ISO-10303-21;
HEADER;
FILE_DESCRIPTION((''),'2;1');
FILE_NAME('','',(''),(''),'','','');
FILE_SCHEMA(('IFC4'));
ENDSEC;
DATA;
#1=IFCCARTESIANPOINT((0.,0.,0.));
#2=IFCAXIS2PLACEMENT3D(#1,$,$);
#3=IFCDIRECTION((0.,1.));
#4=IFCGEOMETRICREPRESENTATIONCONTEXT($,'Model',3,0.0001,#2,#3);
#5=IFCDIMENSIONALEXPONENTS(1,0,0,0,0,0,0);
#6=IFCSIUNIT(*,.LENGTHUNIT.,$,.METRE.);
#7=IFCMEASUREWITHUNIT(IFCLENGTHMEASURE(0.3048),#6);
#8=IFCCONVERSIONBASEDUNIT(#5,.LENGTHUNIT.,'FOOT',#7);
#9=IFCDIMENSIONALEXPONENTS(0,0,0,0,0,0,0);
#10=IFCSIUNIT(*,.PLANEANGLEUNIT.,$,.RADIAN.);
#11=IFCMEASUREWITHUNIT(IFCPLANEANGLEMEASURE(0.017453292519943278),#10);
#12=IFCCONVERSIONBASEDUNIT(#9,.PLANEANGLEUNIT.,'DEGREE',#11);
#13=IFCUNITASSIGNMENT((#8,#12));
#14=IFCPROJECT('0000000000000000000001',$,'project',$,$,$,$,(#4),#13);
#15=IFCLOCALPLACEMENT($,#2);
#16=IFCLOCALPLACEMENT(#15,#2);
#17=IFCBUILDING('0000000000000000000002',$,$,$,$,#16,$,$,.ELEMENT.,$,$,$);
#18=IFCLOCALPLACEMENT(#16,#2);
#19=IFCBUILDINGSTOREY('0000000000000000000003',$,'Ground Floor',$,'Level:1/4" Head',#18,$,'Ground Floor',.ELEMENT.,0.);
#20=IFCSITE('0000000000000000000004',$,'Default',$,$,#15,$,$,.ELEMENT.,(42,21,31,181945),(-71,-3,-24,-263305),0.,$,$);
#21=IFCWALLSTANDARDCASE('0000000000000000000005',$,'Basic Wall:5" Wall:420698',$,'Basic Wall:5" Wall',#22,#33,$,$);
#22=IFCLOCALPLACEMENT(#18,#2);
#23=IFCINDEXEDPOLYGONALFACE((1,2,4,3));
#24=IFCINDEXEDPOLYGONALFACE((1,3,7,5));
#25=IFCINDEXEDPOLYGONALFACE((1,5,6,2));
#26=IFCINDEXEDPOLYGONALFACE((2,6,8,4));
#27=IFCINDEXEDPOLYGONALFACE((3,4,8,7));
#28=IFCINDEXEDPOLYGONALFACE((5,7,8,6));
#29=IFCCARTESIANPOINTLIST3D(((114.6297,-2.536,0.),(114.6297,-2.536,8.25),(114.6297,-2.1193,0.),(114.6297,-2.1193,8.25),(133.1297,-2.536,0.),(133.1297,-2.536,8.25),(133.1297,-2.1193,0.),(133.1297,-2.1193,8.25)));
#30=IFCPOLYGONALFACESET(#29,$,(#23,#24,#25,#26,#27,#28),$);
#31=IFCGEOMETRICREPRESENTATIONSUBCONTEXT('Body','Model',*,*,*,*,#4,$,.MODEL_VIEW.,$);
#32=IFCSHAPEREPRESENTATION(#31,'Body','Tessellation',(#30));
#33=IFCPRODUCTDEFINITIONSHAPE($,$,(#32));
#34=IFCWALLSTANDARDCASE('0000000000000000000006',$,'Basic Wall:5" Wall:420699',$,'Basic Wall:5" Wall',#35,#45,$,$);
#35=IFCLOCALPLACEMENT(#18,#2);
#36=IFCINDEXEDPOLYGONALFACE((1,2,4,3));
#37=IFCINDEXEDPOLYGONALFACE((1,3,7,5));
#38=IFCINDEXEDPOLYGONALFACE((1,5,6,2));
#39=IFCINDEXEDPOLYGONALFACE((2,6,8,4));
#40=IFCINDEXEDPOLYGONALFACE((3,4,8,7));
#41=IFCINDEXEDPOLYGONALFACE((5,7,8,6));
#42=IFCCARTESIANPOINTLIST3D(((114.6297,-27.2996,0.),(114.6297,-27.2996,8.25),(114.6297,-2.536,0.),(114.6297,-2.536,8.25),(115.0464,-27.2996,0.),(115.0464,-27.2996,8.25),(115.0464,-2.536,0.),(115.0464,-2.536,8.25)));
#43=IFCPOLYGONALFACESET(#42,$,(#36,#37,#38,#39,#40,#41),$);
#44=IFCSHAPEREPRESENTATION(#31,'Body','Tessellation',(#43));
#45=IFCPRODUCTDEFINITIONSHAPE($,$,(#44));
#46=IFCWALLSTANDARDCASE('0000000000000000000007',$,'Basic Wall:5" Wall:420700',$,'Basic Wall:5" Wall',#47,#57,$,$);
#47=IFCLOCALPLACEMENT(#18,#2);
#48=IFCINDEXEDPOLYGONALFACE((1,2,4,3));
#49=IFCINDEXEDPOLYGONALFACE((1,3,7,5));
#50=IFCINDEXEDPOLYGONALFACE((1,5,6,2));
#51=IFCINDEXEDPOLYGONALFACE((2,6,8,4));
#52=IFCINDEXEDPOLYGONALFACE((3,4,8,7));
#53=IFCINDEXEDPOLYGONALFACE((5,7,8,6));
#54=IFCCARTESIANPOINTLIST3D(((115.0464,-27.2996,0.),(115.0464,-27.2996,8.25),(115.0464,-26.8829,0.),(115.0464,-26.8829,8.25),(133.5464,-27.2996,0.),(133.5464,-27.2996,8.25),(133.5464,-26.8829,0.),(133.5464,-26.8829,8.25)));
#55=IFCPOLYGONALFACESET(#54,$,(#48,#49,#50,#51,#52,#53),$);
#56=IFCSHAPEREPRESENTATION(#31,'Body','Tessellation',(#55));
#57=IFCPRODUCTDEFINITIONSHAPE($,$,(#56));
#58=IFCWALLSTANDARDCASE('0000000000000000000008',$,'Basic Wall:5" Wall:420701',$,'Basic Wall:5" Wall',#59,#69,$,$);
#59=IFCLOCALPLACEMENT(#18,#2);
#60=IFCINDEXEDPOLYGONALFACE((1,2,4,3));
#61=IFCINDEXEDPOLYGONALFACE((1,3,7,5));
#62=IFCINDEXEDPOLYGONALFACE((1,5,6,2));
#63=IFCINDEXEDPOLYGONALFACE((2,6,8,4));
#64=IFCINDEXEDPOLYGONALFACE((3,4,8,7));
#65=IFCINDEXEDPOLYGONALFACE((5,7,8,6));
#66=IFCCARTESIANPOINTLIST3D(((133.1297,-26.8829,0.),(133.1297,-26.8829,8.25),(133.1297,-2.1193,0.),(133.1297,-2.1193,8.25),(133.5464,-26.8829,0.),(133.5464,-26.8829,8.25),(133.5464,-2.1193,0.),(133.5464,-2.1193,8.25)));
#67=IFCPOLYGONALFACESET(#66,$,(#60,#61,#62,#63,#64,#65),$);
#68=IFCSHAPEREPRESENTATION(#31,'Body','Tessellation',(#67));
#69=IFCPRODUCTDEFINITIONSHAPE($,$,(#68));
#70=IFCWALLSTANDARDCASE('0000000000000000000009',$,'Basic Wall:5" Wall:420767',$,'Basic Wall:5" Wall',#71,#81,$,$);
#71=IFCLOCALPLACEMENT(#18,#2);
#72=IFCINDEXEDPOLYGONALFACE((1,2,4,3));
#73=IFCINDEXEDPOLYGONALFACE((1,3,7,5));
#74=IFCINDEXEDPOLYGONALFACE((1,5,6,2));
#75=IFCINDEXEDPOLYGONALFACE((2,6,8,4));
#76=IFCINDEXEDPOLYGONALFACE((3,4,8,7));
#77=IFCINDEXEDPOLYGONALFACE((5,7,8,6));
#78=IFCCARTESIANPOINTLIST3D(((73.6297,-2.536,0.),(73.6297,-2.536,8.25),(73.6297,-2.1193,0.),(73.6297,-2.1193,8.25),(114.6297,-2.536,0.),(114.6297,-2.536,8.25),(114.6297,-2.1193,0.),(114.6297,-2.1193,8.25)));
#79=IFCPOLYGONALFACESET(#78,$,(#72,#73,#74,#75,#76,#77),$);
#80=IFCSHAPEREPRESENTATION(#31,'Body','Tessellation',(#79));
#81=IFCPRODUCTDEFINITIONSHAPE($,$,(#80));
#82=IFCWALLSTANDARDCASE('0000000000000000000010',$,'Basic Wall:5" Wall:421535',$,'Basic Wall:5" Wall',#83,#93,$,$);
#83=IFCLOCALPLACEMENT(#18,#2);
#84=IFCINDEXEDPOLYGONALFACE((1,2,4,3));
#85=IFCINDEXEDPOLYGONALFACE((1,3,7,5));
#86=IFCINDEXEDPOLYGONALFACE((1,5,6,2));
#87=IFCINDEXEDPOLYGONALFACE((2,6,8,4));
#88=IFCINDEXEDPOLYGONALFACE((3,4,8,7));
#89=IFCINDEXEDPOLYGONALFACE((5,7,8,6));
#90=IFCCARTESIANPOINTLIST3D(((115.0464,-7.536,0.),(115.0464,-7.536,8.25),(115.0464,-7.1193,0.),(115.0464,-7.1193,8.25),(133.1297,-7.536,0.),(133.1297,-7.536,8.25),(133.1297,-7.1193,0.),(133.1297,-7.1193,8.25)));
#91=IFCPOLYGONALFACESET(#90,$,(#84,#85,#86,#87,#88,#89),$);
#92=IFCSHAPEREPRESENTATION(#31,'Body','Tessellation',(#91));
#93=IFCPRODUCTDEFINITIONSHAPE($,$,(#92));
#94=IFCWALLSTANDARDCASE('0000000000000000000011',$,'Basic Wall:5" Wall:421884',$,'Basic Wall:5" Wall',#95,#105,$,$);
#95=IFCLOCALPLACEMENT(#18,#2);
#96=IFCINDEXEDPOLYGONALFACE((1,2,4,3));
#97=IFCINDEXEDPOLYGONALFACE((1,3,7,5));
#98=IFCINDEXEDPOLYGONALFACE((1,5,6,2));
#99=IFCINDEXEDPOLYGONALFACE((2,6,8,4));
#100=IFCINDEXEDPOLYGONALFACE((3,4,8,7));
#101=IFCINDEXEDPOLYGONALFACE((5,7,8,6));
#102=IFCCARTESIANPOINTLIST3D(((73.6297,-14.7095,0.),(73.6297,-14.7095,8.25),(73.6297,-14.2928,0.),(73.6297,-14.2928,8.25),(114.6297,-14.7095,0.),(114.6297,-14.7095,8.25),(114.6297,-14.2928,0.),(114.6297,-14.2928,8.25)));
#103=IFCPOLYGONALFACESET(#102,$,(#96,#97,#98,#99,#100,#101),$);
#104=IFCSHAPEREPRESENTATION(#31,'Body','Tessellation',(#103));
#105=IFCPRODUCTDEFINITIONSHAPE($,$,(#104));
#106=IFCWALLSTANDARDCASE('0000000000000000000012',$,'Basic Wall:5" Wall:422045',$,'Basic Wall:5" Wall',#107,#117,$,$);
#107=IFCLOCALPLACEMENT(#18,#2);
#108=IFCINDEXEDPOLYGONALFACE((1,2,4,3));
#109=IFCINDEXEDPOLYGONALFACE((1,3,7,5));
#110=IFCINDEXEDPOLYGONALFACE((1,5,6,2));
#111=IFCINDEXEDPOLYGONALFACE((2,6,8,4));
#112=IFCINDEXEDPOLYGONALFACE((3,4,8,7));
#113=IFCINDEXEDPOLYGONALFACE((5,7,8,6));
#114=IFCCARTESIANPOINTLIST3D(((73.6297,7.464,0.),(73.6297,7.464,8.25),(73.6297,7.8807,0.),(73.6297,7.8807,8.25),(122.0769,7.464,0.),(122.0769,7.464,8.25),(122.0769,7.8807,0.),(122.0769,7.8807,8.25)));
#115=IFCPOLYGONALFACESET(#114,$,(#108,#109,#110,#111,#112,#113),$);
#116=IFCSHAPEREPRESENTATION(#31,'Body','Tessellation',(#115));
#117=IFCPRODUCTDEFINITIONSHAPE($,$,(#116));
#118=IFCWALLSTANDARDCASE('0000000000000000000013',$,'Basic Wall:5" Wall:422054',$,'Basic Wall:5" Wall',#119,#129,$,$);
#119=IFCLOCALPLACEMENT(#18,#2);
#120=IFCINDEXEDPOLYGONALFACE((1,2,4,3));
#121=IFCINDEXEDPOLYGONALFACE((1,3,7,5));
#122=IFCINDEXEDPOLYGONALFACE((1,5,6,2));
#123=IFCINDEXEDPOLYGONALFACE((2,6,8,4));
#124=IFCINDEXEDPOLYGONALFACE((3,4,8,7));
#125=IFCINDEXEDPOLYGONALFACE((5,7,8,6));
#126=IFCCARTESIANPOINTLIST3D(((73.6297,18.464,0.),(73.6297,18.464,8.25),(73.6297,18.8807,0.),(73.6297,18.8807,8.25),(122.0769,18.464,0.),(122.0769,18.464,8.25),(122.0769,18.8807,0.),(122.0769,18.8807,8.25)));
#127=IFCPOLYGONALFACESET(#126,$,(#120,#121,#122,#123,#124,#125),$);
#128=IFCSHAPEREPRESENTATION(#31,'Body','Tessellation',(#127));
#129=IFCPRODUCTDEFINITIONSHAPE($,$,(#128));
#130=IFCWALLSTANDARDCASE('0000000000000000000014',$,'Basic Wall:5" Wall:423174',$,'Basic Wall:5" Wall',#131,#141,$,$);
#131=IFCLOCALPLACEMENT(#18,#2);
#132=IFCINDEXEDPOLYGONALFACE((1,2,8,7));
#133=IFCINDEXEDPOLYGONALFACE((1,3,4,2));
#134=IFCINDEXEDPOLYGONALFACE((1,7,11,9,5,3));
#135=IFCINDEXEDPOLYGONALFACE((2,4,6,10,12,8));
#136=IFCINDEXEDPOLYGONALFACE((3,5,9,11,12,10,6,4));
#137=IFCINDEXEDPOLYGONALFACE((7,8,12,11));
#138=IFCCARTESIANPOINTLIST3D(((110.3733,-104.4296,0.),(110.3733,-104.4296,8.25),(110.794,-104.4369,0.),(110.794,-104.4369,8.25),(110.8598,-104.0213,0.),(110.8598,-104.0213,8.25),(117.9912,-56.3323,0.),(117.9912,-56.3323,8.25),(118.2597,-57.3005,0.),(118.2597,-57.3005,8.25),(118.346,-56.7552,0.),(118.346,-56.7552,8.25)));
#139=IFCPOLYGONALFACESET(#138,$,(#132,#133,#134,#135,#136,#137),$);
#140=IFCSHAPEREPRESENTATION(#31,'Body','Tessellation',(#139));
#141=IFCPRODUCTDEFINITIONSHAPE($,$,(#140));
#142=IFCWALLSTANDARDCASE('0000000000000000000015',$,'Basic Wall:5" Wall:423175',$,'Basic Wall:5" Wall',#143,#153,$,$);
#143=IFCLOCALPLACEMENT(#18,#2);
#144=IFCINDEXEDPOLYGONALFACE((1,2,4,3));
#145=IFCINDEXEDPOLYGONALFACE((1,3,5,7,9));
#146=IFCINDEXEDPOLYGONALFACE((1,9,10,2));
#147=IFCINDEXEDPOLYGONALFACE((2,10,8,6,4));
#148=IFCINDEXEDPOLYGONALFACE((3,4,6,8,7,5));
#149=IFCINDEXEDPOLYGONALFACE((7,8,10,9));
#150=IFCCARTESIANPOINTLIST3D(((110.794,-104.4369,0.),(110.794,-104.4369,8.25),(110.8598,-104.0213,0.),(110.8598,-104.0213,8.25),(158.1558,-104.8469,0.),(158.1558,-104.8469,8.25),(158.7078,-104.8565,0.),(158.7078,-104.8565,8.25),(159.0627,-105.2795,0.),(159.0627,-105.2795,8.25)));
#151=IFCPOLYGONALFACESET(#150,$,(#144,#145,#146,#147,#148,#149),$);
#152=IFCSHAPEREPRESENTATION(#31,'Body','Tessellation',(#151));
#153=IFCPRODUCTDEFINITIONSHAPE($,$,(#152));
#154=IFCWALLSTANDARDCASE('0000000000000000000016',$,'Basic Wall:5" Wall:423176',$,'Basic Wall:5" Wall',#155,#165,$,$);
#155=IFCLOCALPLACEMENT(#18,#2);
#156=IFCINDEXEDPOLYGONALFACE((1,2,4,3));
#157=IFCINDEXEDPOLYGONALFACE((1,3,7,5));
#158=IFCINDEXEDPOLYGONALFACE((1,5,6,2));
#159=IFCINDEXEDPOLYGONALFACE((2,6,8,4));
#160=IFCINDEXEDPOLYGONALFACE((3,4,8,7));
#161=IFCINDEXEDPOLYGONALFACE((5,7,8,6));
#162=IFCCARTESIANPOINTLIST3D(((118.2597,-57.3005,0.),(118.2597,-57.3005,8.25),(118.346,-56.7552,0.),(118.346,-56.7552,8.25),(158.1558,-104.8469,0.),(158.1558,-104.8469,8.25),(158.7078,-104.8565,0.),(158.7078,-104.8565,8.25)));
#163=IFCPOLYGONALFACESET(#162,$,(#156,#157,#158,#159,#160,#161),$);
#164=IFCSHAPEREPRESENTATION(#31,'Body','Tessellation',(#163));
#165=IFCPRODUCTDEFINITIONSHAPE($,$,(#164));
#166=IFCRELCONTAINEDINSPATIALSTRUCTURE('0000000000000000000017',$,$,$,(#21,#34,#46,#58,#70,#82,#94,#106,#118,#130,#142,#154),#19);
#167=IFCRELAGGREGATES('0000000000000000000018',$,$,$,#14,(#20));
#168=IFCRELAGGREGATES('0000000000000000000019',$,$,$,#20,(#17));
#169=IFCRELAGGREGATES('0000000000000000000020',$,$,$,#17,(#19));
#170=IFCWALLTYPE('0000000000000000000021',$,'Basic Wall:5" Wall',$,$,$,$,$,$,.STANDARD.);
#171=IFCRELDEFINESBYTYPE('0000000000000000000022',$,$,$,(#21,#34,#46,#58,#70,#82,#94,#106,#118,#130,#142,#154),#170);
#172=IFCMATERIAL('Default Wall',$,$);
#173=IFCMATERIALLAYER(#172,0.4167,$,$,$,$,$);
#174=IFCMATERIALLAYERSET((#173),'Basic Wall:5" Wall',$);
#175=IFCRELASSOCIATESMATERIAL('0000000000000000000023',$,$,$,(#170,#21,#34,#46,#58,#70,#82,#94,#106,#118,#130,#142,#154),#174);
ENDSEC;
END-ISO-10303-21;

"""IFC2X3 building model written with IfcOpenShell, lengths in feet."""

from ifc_helpers import new_model, entity, si_unit, converted_unit, direction, frame, frame_2d, origin, place, context, subcontext, project, spatial, polyline, rectangle, outline, extrude, material, layer, layer_set, layer_usage, type_object, element, save


model = new_model("IFC2X3")

# Units and contexts
model_context = context("Model", 3, precision=0.0001, world=origin(), true_north=direction((0.0, 1.0)))
body_context = subcontext(model_context, "Body", "Model", "MODEL_VIEW")
ifc_project = project(units=[converted_unit("LENGTHUNIT", "FOOT", entity("IfcLengthMeasure", 0.3048), si_unit("LENGTHUNIT", "METRE"), dimensions=[1, 0, 0, 0, 0, 0, 0]), converted_unit("PLANEANGLEUNIT", "DEGREE", entity("IfcPlaneAngleMeasure", 0.017453292519943278), si_unit("PLANEANGLEUNIT", "RADIAN"), dimensions=[0, 0, 0, 0, 0, 0, 0])], contexts=[model_context])

# Site, building, storey
site_placement = place(None, origin())
site = spatial("IfcSite", under=ifc_project, at=site_placement, Name="Default", CompositionType="ELEMENT", RefLatitude=(42, 21, 31, 181945), RefLongitude=(-71, -3, -24, -263305), RefElevation=0.0)
building_placement = place(site_placement, origin())
building = spatial("IfcBuilding", under=site, at=building_placement, CompositionType="ELEMENT")
storey_placement = place(building_placement, origin())
storey = spatial("IfcBuildingStorey", under=building, at=storey_placement, Name="Ground Floor", ObjectType="Level:1/4\" Head", LongName="Ground Floor", CompositionType="ELEMENT", Elevation=0.0)

# Shared definitions
ifc_material_1 = material(Name="Default Wall")

# Shared definitions
ifc_layer_1 = layer(ifc_material_1, 0.4167)
ifc_layer_set_1 = layer_set([ifc_layer_1], Name="Basic Wall:5\" Wall")
ifc_layer_usage_1 = layer_usage(ifc_layer_set_1, "AXIS2", "NEGATIVE", 0.2083)
wall_type_1 = type_object("IfcWallType", Name="Basic Wall:5\" Wall", PredefinedType="STANDARD", material=ifc_layer_set_1)

# Walls
wall_1_placement = place(storey_placement, frame((114.6297, -2.3277, 0.0)))
element("IfcWallStandardCase", 1, at=wall_1_placement, inside=storey, type_object=wall_type_1, material=ifc_layer_usage_1, Name="Basic Wall:5\" Wall:420698", ObjectType="Basic Wall:5\" Wall", context=body_context, shape_type="SweptSolid", body=[
    extrude(rectangle(XDim=18.5, YDim=0.4167, at=frame_2d((9.25, 0.0), x_axis=(-1.0, 0.0))), origin(), (0.0, 0.0, 1.0), 8.25),
])
wall_2_placement = place(storey_placement, frame((114.838, -27.2996, 0.0), z_axis=(0.0, 0.0, 1.0), x_axis=(0.0, 1.0, 0.0)))
element("IfcWallStandardCase", 2, at=wall_2_placement, inside=storey, type_object=wall_type_1, material=ifc_layer_usage_1, Name="Basic Wall:5\" Wall:420699", ObjectType="Basic Wall:5\" Wall", context=body_context, shape_type="SweptSolid", body=[
    extrude(rectangle(XDim=24.7636, YDim=0.4167, at=frame_2d((12.3818, 0.0), x_axis=(-1.0, 0.0))), origin(), (0.0, 0.0, 1.0), 8.25),
])
wall_3_placement = place(storey_placement, frame((133.5464, -27.0912, 0.0), z_axis=(0.0, 0.0, 1.0), x_axis=(-1.0, 0.0, 0.0)))
element("IfcWallStandardCase", 3, at=wall_3_placement, inside=storey, type_object=wall_type_1, material=ifc_layer_usage_1, Name="Basic Wall:5\" Wall:420700", ObjectType="Basic Wall:5\" Wall", context=body_context, shape_type="SweptSolid", body=[
    extrude(rectangle(XDim=18.5, YDim=0.4167, at=frame_2d((9.25, 0.0), x_axis=(-1.0, 0.0))), origin(), (0.0, 0.0, 1.0), 8.25),
])
wall_4_placement = place(storey_placement, frame((133.338, -2.1193, 0.0), z_axis=(0.0, 0.0, 1.0), x_axis=(0.0, -1.0, 0.0)))
element("IfcWallStandardCase", 4, at=wall_4_placement, inside=storey, type_object=wall_type_1, material=ifc_layer_usage_1, Name="Basic Wall:5\" Wall:420701", ObjectType="Basic Wall:5\" Wall", context=body_context, shape_type="SweptSolid", body=[
    extrude(rectangle(XDim=24.7636, YDim=0.4167, at=frame_2d((12.3818, 0.0), x_axis=(-1.0, 0.0))), origin(), (0.0, 0.0, 1.0), 8.25),
])
wall_5_placement = place(storey_placement, frame((73.6297, -2.3277, 0.0)))
element("IfcWallStandardCase", 5, at=wall_5_placement, inside=storey, type_object=wall_type_1, material=ifc_layer_usage_1, Name="Basic Wall:5\" Wall:420767", ObjectType="Basic Wall:5\" Wall", context=body_context, shape_type="SweptSolid", body=[
    extrude(rectangle(XDim=41.0, YDim=0.4167, at=frame_2d((20.5, 0.0), x_axis=(-1.0, 0.0))), origin(), (0.0, 0.0, 1.0), 8.25),
])
wall_6_placement = place(storey_placement, frame((115.0464, -7.3277, 0.0)))
element("IfcWallStandardCase", 6, at=wall_6_placement, inside=storey, type_object=wall_type_1, material=ifc_layer_usage_1, Name="Basic Wall:5\" Wall:421535", ObjectType="Basic Wall:5\" Wall", context=body_context, shape_type="SweptSolid", body=[
    extrude(rectangle(XDim=18.0833, YDim=0.4167, at=frame_2d((9.0417, 0.0), x_axis=(-1.0, 0.0))), origin(), (0.0, 0.0, 1.0), 8.25),
])
wall_7_placement = place(storey_placement, frame((73.6297, -14.5011, 0.0)))
element("IfcWallStandardCase", 7, at=wall_7_placement, inside=storey, type_object=wall_type_1, material=ifc_layer_usage_1, Name="Basic Wall:5\" Wall:421884", ObjectType="Basic Wall:5\" Wall", context=body_context, shape_type="SweptSolid", body=[
    extrude(rectangle(XDim=41.0, YDim=0.4167, at=frame_2d((20.5, 0.0), x_axis=(-1.0, 0.0))), origin(), (0.0, 0.0, 1.0), 8.25),
])
wall_8_placement = place(storey_placement, frame((73.6297, 7.6723, 0.0)))
element("IfcWallStandardCase", 8, at=wall_8_placement, inside=storey, type_object=wall_type_1, material=ifc_layer_usage_1, Name="Basic Wall:5\" Wall:422045", ObjectType="Basic Wall:5\" Wall", context=body_context, shape_type="SweptSolid", body=[
    extrude(rectangle(XDim=48.4472, YDim=0.4167, at=frame_2d((24.2236, 0.0), x_axis=(-1.0, 0.0))), origin(), (0.0, 0.0, 1.0), 8.25),
])
wall_9_placement = place(storey_placement, frame((73.6297, 18.6723, 0.0)))
element("IfcWallStandardCase", 9, at=wall_9_placement, inside=storey, type_object=wall_type_1, material=ifc_layer_usage_1, Name="Basic Wall:5\" Wall:422054", ObjectType="Basic Wall:5\" Wall", context=body_context, shape_type="SweptSolid", body=[
    extrude(rectangle(XDim=48.4472, YDim=0.4167, at=frame_2d((24.2236, 0.0), x_axis=(-1.0, 0.0))), origin(), (0.0, 0.0, 1.0), 8.25),
])
ifc_layer_usage_2 = layer_usage(ifc_layer_set_1, "AXIS2", "POSITIVE", -0.2083)
wall_10_placement = place(storey_placement, frame((118.1969, -56.3649, 0.0), z_axis=(0.0, 0.0, 1.0), x_axis=(-0.156434, -0.987688, 0.0)))
element("IfcWallStandardCase", 10, at=wall_10_placement, inside=storey, type_object=wall_type_1, material=ifc_layer_usage_2, Name="Basic Wall:5\" Wall:423174", ObjectType="Basic Wall:5\" Wall", context=body_context, shape_type="SweptSolid", body=[
    extrude(outline(polyline([(48.6968, -0.2083), (48.6382, 0.2083), (48.2175, 0.2083), (0.9143, 0.2083), (0.3622, 0.2083), (0.0, -0.2083), (48.6968, -0.2083)])), origin(), (0.0, 0.0, 1.0), 8.25),
])
wall_11_placement = place(storey_placement, frame((110.7976, -104.2286, 0.0), z_axis=(0.0, 0.0, 1.0), x_axis=(0.999848, -0.017452, 0.0)))
element("IfcWallStandardCase", 11, at=wall_11_placement, inside=storey, type_object=wall_type_1, material=ifc_layer_usage_2, Name="Basic Wall:5\" Wall:423175", ObjectType="Basic Wall:5\" Wall", context=body_context, shape_type="SweptSolid", body=[
    extrude(outline(polyline([(48.276, -0.2083), (47.9138, 0.2083), (47.3618, 0.2083), (0.0586, 0.2083), (0.0, -0.2083), (48.276, -0.2083)])), origin(), (0.0, 0.0, 1.0), 8.25),
])
wall_12_placement = place(storey_placement, frame((158.5482, -104.9904, 0.0), z_axis=(0.0, 0.0, 1.0), x_axis=(-0.642788, 0.766044, 0.0)))
element("IfcWallStandardCase", 12, at=wall_12_placement, inside=storey, type_object=wall_type_1, material=ifc_layer_usage_2, Name="Basic Wall:5\" Wall:423176", ObjectType="Basic Wall:5\" Wall", context=body_context, shape_type="SweptSolid", body=[
    extrude(outline(polyline([(62.7918, -0.2083), (62.4296, 0.2083), (0.3622, 0.2083), (0.0, -0.2083), (62.7918, -0.2083)])), origin(), (0.0, 0.0, 1.0), 8.25),
])

save(model, "model.ifc")
